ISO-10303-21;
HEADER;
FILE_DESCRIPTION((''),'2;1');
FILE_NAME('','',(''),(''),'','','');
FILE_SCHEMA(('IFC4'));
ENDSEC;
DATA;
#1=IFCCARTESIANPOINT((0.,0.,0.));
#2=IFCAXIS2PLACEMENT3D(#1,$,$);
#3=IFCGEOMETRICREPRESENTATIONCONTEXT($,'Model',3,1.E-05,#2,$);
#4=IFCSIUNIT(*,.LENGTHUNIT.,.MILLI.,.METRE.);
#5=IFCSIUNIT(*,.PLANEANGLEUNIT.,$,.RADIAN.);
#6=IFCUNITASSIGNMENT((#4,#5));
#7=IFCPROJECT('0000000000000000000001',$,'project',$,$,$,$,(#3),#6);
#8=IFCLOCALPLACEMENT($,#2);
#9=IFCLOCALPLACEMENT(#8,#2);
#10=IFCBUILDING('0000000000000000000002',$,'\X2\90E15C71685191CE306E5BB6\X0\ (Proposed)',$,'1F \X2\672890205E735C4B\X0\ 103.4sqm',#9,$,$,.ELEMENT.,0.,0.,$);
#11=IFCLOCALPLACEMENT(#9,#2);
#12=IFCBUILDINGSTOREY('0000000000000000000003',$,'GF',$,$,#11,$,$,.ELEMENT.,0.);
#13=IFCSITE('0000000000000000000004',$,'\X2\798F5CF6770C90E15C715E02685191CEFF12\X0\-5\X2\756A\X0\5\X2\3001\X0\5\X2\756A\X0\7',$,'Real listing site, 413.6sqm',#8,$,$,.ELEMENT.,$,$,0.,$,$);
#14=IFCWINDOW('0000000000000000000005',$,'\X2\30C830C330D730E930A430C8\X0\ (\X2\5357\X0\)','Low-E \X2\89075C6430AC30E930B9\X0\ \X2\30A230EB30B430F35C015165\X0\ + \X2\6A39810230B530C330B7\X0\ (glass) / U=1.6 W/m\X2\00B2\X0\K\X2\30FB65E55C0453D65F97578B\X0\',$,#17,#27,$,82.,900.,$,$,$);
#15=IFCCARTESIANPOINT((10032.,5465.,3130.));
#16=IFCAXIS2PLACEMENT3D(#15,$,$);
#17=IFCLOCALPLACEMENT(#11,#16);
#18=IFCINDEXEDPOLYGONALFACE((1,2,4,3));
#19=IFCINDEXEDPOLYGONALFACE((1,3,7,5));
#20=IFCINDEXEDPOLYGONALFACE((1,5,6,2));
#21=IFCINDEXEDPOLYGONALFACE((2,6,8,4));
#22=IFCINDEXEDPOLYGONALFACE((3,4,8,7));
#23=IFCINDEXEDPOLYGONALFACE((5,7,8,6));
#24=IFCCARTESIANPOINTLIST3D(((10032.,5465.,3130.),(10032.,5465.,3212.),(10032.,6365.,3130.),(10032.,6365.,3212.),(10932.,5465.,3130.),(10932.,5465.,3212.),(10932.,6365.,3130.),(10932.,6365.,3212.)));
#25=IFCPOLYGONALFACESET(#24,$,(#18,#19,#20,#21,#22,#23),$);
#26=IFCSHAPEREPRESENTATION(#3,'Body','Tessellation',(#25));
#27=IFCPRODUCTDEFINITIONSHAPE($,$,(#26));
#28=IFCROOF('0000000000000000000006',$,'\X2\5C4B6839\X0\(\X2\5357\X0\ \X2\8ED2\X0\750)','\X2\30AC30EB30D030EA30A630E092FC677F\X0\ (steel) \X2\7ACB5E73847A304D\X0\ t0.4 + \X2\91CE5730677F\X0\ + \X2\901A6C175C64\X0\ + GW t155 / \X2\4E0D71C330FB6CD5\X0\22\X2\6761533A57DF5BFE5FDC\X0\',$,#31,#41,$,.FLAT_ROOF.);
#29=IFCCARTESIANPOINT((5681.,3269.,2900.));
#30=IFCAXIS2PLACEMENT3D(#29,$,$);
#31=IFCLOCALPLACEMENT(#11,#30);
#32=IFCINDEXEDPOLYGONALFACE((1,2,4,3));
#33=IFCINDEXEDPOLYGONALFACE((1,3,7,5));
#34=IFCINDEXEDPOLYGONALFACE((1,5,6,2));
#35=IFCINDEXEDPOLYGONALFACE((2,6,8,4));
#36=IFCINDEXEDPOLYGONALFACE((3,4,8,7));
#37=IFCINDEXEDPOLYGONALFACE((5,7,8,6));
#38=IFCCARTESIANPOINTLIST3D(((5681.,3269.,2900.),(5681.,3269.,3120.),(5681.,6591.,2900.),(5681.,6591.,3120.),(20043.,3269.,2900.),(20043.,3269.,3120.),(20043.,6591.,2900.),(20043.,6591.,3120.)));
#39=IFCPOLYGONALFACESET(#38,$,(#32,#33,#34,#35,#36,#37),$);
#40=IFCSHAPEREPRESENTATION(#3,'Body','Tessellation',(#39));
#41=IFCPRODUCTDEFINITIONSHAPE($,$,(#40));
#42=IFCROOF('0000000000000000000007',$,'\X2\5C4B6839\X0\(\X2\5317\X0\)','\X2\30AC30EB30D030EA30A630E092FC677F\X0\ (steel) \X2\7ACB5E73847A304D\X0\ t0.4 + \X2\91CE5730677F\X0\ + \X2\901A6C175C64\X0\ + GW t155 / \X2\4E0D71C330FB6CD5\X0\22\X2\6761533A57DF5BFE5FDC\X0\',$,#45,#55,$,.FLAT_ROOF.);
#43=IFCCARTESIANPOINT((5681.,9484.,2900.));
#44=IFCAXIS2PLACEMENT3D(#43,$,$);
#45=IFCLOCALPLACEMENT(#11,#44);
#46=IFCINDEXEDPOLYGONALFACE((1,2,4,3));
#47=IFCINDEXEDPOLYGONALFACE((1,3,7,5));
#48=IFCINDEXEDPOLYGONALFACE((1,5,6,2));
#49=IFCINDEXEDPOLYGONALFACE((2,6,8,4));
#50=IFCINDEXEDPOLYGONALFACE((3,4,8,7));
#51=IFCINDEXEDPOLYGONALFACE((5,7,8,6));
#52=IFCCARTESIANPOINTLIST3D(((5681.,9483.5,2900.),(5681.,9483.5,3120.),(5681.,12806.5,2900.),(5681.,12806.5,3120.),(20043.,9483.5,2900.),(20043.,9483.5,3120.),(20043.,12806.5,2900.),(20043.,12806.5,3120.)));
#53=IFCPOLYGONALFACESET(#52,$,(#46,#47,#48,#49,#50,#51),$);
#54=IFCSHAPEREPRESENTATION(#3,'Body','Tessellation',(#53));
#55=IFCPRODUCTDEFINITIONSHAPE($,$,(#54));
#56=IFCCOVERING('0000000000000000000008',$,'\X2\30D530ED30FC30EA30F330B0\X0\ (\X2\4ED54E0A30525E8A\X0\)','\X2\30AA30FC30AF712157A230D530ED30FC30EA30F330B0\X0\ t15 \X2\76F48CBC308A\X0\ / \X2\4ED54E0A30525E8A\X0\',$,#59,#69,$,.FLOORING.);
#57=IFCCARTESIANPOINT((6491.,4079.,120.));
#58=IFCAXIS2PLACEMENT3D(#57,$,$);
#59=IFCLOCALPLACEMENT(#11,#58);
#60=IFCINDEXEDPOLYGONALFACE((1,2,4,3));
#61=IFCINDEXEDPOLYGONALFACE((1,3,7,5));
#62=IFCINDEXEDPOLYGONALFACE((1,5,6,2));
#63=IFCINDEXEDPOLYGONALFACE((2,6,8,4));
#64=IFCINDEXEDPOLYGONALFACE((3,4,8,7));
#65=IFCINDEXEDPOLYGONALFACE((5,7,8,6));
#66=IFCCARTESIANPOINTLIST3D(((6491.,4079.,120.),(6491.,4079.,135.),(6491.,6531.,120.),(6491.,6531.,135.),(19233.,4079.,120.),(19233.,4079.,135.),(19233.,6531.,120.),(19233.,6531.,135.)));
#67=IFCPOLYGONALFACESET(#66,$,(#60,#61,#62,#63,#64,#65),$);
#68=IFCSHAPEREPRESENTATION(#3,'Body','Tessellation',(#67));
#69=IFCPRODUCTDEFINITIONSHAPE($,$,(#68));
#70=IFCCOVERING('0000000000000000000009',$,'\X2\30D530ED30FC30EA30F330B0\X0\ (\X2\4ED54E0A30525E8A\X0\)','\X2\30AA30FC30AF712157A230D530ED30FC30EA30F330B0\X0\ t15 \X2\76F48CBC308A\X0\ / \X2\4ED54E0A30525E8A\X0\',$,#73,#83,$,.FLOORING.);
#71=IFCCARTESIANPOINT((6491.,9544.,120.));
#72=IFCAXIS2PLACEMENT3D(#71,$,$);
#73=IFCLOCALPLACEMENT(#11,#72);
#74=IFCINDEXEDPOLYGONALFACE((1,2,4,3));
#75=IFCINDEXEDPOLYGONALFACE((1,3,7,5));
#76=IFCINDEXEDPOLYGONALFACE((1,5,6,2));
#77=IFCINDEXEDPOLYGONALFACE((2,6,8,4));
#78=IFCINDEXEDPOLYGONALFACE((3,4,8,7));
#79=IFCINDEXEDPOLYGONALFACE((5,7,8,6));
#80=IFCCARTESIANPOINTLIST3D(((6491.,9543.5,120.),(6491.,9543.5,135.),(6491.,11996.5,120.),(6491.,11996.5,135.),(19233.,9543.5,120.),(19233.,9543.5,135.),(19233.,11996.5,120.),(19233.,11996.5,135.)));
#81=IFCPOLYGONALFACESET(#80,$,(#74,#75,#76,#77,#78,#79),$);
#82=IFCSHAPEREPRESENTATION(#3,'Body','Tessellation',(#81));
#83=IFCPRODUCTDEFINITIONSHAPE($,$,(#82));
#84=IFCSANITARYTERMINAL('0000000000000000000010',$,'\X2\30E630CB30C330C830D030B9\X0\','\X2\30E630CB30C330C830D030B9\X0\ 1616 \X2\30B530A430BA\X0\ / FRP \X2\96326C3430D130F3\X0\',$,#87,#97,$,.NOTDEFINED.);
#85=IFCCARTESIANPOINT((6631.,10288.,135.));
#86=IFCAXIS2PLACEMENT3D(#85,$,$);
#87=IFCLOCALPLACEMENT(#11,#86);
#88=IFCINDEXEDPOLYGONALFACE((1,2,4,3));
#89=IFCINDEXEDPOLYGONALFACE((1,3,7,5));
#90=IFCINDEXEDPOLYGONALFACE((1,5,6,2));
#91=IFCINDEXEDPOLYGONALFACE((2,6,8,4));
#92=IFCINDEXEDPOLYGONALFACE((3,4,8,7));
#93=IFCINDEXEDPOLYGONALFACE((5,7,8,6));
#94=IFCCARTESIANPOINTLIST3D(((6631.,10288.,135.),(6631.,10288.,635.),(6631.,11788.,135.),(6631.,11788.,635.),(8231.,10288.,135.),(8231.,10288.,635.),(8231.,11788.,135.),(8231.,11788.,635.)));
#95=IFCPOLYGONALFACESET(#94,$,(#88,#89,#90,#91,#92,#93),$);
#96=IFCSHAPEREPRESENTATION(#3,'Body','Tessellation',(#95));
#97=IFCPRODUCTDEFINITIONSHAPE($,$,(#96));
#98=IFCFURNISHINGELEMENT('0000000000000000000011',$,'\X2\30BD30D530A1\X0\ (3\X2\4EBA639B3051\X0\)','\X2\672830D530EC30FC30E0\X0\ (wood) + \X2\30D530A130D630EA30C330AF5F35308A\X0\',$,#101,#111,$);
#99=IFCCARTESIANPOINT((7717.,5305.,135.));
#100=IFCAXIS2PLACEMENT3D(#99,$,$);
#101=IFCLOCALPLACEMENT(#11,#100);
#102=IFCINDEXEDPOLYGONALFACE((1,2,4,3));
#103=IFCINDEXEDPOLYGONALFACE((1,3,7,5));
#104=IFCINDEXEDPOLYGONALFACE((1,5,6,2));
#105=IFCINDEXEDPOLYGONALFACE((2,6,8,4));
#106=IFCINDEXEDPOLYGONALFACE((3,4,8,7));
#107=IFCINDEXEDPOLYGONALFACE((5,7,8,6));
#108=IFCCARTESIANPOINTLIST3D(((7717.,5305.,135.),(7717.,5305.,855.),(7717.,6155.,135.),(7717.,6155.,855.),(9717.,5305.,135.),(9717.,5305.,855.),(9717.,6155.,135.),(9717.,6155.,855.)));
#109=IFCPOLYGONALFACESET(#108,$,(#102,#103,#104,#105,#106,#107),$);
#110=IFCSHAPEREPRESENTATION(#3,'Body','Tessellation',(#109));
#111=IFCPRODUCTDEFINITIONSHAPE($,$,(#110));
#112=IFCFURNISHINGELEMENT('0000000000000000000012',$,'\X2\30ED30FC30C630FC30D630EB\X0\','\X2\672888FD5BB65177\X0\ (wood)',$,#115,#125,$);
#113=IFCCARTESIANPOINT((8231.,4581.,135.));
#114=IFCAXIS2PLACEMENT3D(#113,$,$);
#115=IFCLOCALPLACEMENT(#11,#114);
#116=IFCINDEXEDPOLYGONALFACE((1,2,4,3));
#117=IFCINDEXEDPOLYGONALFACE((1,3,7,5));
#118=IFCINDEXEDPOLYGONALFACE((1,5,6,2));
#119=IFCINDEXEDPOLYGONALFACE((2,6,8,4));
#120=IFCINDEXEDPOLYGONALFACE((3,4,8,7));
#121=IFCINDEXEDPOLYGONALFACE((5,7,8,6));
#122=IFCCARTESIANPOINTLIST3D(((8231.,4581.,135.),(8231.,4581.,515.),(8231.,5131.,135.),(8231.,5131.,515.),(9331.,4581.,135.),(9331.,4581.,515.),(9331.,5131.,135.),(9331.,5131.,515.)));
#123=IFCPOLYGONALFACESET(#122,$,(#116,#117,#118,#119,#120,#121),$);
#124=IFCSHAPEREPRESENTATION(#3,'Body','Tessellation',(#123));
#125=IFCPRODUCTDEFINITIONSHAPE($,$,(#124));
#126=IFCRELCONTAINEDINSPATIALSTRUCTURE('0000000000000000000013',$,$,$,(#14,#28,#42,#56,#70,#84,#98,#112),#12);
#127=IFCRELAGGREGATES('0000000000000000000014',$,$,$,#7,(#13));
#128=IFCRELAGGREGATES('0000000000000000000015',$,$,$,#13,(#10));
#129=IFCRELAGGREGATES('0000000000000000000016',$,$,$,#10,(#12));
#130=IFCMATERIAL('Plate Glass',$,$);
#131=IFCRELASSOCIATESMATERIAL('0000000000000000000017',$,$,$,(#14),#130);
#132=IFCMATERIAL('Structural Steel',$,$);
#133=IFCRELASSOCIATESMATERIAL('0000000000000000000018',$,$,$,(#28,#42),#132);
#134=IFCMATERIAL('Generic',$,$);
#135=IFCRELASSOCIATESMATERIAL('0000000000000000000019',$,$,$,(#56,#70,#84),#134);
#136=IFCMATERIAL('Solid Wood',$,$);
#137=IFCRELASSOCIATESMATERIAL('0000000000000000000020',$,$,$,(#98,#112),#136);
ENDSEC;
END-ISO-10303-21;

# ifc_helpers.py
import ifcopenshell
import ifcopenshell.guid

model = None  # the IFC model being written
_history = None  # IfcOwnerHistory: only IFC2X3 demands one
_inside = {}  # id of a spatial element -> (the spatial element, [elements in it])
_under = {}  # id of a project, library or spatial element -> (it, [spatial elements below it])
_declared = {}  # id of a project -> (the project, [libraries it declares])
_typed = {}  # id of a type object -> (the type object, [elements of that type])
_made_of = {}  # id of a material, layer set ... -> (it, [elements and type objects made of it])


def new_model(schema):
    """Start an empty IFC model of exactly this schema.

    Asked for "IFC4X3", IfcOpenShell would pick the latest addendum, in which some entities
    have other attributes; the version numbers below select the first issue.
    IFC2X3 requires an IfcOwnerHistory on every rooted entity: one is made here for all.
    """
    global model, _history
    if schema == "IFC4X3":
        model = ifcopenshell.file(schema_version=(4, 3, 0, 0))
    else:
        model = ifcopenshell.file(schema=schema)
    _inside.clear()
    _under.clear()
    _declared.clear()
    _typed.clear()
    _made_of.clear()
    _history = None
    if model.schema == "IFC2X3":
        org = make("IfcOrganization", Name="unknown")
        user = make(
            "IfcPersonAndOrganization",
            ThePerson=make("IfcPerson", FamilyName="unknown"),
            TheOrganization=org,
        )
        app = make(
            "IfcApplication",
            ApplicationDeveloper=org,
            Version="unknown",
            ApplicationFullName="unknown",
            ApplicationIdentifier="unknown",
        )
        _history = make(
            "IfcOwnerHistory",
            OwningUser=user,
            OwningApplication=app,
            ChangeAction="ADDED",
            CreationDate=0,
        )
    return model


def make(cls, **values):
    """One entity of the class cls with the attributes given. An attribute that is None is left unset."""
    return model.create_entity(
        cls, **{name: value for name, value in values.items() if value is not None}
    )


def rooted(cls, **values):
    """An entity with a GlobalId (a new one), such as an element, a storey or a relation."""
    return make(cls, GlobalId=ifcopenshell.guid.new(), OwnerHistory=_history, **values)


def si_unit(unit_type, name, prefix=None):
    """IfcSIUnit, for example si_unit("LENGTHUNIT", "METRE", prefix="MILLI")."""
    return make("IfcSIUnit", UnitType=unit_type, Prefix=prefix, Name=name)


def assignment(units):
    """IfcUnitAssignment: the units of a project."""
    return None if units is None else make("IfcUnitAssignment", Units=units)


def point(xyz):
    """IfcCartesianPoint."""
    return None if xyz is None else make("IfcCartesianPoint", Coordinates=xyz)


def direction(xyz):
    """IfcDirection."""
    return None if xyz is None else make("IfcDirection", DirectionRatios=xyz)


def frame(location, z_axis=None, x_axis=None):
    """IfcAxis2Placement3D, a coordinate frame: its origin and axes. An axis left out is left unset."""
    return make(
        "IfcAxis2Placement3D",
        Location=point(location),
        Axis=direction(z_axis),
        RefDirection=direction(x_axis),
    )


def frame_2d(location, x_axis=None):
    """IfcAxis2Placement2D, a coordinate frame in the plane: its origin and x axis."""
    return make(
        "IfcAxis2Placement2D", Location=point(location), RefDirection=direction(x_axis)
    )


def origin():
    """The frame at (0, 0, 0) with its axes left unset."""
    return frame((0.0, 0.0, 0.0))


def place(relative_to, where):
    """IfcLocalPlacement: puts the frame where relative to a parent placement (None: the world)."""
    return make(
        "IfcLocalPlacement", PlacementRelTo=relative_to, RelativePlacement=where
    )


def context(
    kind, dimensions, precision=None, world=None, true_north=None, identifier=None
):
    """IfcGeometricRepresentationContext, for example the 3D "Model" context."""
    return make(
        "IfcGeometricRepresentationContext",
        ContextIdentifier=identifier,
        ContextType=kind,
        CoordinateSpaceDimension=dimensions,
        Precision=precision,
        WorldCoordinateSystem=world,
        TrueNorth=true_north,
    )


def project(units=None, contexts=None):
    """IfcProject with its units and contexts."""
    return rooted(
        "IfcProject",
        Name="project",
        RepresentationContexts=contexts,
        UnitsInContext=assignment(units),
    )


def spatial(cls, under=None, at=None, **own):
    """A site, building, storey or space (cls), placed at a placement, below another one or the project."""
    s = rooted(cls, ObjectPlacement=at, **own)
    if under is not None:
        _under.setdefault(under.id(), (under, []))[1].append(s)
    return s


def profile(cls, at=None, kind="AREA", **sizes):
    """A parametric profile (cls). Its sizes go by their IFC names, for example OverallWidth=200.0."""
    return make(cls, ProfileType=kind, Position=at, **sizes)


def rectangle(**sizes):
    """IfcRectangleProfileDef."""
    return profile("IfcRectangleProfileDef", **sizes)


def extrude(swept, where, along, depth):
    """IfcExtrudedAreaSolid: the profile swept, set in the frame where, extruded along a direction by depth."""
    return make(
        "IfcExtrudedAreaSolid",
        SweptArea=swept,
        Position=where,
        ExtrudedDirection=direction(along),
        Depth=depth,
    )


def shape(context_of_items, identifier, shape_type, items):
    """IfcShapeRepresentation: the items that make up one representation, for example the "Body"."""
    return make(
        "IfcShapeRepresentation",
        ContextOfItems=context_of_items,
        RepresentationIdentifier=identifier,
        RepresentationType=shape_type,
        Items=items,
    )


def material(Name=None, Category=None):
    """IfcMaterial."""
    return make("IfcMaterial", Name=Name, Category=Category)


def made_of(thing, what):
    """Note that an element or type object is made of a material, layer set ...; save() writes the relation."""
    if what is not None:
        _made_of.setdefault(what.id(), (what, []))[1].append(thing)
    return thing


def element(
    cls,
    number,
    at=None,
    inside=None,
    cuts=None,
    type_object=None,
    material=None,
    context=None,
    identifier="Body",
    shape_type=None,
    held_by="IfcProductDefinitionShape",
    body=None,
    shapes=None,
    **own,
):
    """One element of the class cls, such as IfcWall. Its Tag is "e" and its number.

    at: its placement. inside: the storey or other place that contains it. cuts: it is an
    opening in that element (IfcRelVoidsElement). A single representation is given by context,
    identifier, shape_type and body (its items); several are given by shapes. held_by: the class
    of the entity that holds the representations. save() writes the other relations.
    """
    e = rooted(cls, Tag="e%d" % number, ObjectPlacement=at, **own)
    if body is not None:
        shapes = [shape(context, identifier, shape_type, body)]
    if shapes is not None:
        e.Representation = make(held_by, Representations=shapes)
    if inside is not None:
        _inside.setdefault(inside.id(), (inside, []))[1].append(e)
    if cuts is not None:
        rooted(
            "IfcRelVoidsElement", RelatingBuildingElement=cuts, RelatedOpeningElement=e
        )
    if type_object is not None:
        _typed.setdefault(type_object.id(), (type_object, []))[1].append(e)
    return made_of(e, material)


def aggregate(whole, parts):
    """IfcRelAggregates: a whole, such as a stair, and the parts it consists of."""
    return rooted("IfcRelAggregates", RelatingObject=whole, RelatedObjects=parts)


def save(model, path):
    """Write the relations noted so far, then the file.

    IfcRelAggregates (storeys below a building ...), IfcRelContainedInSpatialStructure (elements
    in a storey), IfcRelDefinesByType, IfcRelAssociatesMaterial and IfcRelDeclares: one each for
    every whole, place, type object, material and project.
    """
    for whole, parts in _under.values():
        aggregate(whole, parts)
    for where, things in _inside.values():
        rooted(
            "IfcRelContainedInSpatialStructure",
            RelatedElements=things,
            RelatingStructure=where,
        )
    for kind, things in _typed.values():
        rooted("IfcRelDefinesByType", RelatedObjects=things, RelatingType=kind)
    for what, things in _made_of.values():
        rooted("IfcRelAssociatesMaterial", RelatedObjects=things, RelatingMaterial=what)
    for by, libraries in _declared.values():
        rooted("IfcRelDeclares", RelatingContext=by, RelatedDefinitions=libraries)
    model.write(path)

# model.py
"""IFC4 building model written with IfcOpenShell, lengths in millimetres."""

from ifc_helpers import new_model, si_unit, frame, frame_2d, origin, place, context, project, spatial, rectangle, extrude, material, element, save


model = new_model("IFC4")

# Units and contexts
model_context = context("Model", 3, precision=1e-05, world=origin())
ifc_project = project(units=[si_unit("LENGTHUNIT", "METRE", prefix="MILLI"), si_unit("PLANEANGLEUNIT", "RADIAN")], contexts=[model_context])

# Site, building, storey
site_placement = place(None, origin())
site = spatial("IfcSite", under=ifc_project, at=site_placement, Name="福島県郡山市桑野２-5番5、5番7", ObjectType="Real listing site, 413.6sqm", CompositionType="ELEMENT", RefElevation=0.0)
building_placement = place(site_placement, origin())
building = spatial("IfcBuilding", under=site, at=building_placement, Name="郡山桑野の家 (Proposed)", ObjectType="1F 木造平屋 103.4sqm", CompositionType="ELEMENT", ElevationOfRefHeight=0.0, ElevationOfTerrain=0.0)
storey_placement = place(building_placement, origin())
storey = spatial("IfcBuildingStorey", under=building, at=storey_placement, Name="GF", CompositionType="ELEMENT", Elevation=0.0)

# Shared definitions
ifc_material_1 = material(Name="Solid Wood")

# Shared definitions
ifc_material_2 = material(Name="Plate Glass")

# Window
window_1_placement = place(storey_placement, frame((10032.0, 5465.0, 3130.0)))
element("IfcWindow", 1, at=window_1_placement, inside=storey, material=ifc_material_2, Name="トップライト (南)", Description="Low-E 複層ガラス アルゴン封入 + 樹脂サッシ (glass) / U=1.6 W/m²K・日射取得型", OverallHeight=82.0, OverallWidth=900.0, context=model_context, shape_type="SweptSolid", body=[
    extrude(rectangle(XDim=900.0, YDim=900.0, at=frame_2d((450.0, 450.0))), frame((10032.0, 5465.0, 3130.0)), (0.0, 0.0, 1.0), 82.0),
])

# Roofs
ifc_material_3 = material(Name="Structural Steel")
roof_1_placement = place(storey_placement, frame((5681.0, 3269.0, 2900.0)))
element("IfcRoof", 2, at=roof_1_placement, inside=storey, material=ifc_material_3, Name="屋根(南 軒750)", Description="ガルバリウム鋼板 (steel) 立平葺き t0.4 + 野地板 + 通気層 + GW t155 / 不燃・法22条区域対応", PredefinedType="FLAT_ROOF", context=model_context, shape_type="SweptSolid", body=[
    extrude(rectangle(XDim=14362.0, YDim=3322.0, at=frame_2d((7181.0, 1661.0))), frame((5681.0, 3269.0, 2900.0)), (0.0, 0.0, 1.0), 220.0),
])
roof_2_placement = place(storey_placement, frame((5681.0, 9484.0, 2900.0)))
element("IfcRoof", 3, at=roof_2_placement, inside=storey, material=ifc_material_3, Name="屋根(北)", Description="ガルバリウム鋼板 (steel) 立平葺き t0.4 + 野地板 + 通気層 + GW t155 / 不燃・法22条区域対応", PredefinedType="FLAT_ROOF", context=model_context, shape_type="SweptSolid", body=[
    extrude(rectangle(XDim=14362.0, YDim=3323.0, at=frame_2d((7181.0, 1661.0))), frame((5681.0, 9484.0, 2900.0)), (0.0, 0.0, 1.0), 220.0),
])

# Coverings
ifc_material_4 = material(Name="Generic")
covering_1_placement = place(storey_placement, frame((6491.0, 4079.0, 120.0)))
element("IfcCovering", 4, at=covering_1_placement, inside=storey, material=ifc_material_4, Name="フローリング (仕上げ床)", Description="オーク無垢フローリング t15 直貼り / 仕上げ床", PredefinedType="FLOORING", context=model_context, shape_type="SweptSolid", body=[
    extrude(rectangle(XDim=12742.0, YDim=2452.0, at=frame_2d((6371.0, 1226.0))), frame((6491.0, 4079.0, 120.0)), (0.0, 0.0, 1.0), 15.0),
])
covering_2_placement = place(storey_placement, frame((6491.0, 9544.0, 120.0)))
element("IfcCovering", 5, at=covering_2_placement, inside=storey, material=ifc_material_4, Name="フローリング (仕上げ床)", Description="オーク無垢フローリング t15 直貼り / 仕上げ床", PredefinedType="FLOORING", context=model_context, shape_type="SweptSolid", body=[
    extrude(rectangle(XDim=12742.0, YDim=2453.0, at=frame_2d((6371.0, 1226.0))), frame((6491.0, 9544.0, 120.0)), (0.0, 0.0, 1.0), 15.0),
])

# Sanitary terminal
sanitary_terminal_placement = place(storey_placement, frame((6631.0, 10288.0, 135.0)))
element("IfcSanitaryTerminal", 6, at=sanitary_terminal_placement, inside=storey, material=ifc_material_4, Name="ユニットバス", Description="ユニットバス 1616 サイズ / FRP 防水パン", PredefinedType="NOTDEFINED", context=model_context, shape_type="SweptSolid", body=[
    extrude(rectangle(XDim=1600.0, YDim=1500.0, at=frame_2d((800.0, 750.0))), frame((6631.0, 10288.0, 135.0)), (0.0, 0.0, 1.0), 500.0),
])

# Furnishing elements
furnishing_1_placement = place(storey_placement, frame((7717.0, 5305.0, 135.0)))
element("IfcFurnishingElement", 7, at=furnishing_1_placement, inside=storey, material=ifc_material_1, Name="ソファ (3人掛け)", Description="木フレーム (wood) + ファブリック張り", context=model_context, shape_type="SweptSolid", body=[
    extrude(rectangle(XDim=2000.0, YDim=850.0, at=frame_2d((1000.0, 425.0))), frame((7717.0, 5305.0, 135.0)), (0.0, 0.0, 1.0), 720.0),
])
furnishing_2_placement = place(storey_placement, frame((8231.0, 4581.0, 135.0)))
element("IfcFurnishingElement", 8, at=furnishing_2_placement, inside=storey, material=ifc_material_1, Name="ローテーブル", Description="木製家具 (wood)", context=model_context, shape_type="SweptSolid", body=[
    extrude(rectangle(XDim=1100.0, YDim=550.0, at=frame_2d((550.0, 275.0))), frame((8231.0, 4581.0, 135.0)), (0.0, 0.0, 1.0), 380.0),
])

save(model, "model.ifc")
